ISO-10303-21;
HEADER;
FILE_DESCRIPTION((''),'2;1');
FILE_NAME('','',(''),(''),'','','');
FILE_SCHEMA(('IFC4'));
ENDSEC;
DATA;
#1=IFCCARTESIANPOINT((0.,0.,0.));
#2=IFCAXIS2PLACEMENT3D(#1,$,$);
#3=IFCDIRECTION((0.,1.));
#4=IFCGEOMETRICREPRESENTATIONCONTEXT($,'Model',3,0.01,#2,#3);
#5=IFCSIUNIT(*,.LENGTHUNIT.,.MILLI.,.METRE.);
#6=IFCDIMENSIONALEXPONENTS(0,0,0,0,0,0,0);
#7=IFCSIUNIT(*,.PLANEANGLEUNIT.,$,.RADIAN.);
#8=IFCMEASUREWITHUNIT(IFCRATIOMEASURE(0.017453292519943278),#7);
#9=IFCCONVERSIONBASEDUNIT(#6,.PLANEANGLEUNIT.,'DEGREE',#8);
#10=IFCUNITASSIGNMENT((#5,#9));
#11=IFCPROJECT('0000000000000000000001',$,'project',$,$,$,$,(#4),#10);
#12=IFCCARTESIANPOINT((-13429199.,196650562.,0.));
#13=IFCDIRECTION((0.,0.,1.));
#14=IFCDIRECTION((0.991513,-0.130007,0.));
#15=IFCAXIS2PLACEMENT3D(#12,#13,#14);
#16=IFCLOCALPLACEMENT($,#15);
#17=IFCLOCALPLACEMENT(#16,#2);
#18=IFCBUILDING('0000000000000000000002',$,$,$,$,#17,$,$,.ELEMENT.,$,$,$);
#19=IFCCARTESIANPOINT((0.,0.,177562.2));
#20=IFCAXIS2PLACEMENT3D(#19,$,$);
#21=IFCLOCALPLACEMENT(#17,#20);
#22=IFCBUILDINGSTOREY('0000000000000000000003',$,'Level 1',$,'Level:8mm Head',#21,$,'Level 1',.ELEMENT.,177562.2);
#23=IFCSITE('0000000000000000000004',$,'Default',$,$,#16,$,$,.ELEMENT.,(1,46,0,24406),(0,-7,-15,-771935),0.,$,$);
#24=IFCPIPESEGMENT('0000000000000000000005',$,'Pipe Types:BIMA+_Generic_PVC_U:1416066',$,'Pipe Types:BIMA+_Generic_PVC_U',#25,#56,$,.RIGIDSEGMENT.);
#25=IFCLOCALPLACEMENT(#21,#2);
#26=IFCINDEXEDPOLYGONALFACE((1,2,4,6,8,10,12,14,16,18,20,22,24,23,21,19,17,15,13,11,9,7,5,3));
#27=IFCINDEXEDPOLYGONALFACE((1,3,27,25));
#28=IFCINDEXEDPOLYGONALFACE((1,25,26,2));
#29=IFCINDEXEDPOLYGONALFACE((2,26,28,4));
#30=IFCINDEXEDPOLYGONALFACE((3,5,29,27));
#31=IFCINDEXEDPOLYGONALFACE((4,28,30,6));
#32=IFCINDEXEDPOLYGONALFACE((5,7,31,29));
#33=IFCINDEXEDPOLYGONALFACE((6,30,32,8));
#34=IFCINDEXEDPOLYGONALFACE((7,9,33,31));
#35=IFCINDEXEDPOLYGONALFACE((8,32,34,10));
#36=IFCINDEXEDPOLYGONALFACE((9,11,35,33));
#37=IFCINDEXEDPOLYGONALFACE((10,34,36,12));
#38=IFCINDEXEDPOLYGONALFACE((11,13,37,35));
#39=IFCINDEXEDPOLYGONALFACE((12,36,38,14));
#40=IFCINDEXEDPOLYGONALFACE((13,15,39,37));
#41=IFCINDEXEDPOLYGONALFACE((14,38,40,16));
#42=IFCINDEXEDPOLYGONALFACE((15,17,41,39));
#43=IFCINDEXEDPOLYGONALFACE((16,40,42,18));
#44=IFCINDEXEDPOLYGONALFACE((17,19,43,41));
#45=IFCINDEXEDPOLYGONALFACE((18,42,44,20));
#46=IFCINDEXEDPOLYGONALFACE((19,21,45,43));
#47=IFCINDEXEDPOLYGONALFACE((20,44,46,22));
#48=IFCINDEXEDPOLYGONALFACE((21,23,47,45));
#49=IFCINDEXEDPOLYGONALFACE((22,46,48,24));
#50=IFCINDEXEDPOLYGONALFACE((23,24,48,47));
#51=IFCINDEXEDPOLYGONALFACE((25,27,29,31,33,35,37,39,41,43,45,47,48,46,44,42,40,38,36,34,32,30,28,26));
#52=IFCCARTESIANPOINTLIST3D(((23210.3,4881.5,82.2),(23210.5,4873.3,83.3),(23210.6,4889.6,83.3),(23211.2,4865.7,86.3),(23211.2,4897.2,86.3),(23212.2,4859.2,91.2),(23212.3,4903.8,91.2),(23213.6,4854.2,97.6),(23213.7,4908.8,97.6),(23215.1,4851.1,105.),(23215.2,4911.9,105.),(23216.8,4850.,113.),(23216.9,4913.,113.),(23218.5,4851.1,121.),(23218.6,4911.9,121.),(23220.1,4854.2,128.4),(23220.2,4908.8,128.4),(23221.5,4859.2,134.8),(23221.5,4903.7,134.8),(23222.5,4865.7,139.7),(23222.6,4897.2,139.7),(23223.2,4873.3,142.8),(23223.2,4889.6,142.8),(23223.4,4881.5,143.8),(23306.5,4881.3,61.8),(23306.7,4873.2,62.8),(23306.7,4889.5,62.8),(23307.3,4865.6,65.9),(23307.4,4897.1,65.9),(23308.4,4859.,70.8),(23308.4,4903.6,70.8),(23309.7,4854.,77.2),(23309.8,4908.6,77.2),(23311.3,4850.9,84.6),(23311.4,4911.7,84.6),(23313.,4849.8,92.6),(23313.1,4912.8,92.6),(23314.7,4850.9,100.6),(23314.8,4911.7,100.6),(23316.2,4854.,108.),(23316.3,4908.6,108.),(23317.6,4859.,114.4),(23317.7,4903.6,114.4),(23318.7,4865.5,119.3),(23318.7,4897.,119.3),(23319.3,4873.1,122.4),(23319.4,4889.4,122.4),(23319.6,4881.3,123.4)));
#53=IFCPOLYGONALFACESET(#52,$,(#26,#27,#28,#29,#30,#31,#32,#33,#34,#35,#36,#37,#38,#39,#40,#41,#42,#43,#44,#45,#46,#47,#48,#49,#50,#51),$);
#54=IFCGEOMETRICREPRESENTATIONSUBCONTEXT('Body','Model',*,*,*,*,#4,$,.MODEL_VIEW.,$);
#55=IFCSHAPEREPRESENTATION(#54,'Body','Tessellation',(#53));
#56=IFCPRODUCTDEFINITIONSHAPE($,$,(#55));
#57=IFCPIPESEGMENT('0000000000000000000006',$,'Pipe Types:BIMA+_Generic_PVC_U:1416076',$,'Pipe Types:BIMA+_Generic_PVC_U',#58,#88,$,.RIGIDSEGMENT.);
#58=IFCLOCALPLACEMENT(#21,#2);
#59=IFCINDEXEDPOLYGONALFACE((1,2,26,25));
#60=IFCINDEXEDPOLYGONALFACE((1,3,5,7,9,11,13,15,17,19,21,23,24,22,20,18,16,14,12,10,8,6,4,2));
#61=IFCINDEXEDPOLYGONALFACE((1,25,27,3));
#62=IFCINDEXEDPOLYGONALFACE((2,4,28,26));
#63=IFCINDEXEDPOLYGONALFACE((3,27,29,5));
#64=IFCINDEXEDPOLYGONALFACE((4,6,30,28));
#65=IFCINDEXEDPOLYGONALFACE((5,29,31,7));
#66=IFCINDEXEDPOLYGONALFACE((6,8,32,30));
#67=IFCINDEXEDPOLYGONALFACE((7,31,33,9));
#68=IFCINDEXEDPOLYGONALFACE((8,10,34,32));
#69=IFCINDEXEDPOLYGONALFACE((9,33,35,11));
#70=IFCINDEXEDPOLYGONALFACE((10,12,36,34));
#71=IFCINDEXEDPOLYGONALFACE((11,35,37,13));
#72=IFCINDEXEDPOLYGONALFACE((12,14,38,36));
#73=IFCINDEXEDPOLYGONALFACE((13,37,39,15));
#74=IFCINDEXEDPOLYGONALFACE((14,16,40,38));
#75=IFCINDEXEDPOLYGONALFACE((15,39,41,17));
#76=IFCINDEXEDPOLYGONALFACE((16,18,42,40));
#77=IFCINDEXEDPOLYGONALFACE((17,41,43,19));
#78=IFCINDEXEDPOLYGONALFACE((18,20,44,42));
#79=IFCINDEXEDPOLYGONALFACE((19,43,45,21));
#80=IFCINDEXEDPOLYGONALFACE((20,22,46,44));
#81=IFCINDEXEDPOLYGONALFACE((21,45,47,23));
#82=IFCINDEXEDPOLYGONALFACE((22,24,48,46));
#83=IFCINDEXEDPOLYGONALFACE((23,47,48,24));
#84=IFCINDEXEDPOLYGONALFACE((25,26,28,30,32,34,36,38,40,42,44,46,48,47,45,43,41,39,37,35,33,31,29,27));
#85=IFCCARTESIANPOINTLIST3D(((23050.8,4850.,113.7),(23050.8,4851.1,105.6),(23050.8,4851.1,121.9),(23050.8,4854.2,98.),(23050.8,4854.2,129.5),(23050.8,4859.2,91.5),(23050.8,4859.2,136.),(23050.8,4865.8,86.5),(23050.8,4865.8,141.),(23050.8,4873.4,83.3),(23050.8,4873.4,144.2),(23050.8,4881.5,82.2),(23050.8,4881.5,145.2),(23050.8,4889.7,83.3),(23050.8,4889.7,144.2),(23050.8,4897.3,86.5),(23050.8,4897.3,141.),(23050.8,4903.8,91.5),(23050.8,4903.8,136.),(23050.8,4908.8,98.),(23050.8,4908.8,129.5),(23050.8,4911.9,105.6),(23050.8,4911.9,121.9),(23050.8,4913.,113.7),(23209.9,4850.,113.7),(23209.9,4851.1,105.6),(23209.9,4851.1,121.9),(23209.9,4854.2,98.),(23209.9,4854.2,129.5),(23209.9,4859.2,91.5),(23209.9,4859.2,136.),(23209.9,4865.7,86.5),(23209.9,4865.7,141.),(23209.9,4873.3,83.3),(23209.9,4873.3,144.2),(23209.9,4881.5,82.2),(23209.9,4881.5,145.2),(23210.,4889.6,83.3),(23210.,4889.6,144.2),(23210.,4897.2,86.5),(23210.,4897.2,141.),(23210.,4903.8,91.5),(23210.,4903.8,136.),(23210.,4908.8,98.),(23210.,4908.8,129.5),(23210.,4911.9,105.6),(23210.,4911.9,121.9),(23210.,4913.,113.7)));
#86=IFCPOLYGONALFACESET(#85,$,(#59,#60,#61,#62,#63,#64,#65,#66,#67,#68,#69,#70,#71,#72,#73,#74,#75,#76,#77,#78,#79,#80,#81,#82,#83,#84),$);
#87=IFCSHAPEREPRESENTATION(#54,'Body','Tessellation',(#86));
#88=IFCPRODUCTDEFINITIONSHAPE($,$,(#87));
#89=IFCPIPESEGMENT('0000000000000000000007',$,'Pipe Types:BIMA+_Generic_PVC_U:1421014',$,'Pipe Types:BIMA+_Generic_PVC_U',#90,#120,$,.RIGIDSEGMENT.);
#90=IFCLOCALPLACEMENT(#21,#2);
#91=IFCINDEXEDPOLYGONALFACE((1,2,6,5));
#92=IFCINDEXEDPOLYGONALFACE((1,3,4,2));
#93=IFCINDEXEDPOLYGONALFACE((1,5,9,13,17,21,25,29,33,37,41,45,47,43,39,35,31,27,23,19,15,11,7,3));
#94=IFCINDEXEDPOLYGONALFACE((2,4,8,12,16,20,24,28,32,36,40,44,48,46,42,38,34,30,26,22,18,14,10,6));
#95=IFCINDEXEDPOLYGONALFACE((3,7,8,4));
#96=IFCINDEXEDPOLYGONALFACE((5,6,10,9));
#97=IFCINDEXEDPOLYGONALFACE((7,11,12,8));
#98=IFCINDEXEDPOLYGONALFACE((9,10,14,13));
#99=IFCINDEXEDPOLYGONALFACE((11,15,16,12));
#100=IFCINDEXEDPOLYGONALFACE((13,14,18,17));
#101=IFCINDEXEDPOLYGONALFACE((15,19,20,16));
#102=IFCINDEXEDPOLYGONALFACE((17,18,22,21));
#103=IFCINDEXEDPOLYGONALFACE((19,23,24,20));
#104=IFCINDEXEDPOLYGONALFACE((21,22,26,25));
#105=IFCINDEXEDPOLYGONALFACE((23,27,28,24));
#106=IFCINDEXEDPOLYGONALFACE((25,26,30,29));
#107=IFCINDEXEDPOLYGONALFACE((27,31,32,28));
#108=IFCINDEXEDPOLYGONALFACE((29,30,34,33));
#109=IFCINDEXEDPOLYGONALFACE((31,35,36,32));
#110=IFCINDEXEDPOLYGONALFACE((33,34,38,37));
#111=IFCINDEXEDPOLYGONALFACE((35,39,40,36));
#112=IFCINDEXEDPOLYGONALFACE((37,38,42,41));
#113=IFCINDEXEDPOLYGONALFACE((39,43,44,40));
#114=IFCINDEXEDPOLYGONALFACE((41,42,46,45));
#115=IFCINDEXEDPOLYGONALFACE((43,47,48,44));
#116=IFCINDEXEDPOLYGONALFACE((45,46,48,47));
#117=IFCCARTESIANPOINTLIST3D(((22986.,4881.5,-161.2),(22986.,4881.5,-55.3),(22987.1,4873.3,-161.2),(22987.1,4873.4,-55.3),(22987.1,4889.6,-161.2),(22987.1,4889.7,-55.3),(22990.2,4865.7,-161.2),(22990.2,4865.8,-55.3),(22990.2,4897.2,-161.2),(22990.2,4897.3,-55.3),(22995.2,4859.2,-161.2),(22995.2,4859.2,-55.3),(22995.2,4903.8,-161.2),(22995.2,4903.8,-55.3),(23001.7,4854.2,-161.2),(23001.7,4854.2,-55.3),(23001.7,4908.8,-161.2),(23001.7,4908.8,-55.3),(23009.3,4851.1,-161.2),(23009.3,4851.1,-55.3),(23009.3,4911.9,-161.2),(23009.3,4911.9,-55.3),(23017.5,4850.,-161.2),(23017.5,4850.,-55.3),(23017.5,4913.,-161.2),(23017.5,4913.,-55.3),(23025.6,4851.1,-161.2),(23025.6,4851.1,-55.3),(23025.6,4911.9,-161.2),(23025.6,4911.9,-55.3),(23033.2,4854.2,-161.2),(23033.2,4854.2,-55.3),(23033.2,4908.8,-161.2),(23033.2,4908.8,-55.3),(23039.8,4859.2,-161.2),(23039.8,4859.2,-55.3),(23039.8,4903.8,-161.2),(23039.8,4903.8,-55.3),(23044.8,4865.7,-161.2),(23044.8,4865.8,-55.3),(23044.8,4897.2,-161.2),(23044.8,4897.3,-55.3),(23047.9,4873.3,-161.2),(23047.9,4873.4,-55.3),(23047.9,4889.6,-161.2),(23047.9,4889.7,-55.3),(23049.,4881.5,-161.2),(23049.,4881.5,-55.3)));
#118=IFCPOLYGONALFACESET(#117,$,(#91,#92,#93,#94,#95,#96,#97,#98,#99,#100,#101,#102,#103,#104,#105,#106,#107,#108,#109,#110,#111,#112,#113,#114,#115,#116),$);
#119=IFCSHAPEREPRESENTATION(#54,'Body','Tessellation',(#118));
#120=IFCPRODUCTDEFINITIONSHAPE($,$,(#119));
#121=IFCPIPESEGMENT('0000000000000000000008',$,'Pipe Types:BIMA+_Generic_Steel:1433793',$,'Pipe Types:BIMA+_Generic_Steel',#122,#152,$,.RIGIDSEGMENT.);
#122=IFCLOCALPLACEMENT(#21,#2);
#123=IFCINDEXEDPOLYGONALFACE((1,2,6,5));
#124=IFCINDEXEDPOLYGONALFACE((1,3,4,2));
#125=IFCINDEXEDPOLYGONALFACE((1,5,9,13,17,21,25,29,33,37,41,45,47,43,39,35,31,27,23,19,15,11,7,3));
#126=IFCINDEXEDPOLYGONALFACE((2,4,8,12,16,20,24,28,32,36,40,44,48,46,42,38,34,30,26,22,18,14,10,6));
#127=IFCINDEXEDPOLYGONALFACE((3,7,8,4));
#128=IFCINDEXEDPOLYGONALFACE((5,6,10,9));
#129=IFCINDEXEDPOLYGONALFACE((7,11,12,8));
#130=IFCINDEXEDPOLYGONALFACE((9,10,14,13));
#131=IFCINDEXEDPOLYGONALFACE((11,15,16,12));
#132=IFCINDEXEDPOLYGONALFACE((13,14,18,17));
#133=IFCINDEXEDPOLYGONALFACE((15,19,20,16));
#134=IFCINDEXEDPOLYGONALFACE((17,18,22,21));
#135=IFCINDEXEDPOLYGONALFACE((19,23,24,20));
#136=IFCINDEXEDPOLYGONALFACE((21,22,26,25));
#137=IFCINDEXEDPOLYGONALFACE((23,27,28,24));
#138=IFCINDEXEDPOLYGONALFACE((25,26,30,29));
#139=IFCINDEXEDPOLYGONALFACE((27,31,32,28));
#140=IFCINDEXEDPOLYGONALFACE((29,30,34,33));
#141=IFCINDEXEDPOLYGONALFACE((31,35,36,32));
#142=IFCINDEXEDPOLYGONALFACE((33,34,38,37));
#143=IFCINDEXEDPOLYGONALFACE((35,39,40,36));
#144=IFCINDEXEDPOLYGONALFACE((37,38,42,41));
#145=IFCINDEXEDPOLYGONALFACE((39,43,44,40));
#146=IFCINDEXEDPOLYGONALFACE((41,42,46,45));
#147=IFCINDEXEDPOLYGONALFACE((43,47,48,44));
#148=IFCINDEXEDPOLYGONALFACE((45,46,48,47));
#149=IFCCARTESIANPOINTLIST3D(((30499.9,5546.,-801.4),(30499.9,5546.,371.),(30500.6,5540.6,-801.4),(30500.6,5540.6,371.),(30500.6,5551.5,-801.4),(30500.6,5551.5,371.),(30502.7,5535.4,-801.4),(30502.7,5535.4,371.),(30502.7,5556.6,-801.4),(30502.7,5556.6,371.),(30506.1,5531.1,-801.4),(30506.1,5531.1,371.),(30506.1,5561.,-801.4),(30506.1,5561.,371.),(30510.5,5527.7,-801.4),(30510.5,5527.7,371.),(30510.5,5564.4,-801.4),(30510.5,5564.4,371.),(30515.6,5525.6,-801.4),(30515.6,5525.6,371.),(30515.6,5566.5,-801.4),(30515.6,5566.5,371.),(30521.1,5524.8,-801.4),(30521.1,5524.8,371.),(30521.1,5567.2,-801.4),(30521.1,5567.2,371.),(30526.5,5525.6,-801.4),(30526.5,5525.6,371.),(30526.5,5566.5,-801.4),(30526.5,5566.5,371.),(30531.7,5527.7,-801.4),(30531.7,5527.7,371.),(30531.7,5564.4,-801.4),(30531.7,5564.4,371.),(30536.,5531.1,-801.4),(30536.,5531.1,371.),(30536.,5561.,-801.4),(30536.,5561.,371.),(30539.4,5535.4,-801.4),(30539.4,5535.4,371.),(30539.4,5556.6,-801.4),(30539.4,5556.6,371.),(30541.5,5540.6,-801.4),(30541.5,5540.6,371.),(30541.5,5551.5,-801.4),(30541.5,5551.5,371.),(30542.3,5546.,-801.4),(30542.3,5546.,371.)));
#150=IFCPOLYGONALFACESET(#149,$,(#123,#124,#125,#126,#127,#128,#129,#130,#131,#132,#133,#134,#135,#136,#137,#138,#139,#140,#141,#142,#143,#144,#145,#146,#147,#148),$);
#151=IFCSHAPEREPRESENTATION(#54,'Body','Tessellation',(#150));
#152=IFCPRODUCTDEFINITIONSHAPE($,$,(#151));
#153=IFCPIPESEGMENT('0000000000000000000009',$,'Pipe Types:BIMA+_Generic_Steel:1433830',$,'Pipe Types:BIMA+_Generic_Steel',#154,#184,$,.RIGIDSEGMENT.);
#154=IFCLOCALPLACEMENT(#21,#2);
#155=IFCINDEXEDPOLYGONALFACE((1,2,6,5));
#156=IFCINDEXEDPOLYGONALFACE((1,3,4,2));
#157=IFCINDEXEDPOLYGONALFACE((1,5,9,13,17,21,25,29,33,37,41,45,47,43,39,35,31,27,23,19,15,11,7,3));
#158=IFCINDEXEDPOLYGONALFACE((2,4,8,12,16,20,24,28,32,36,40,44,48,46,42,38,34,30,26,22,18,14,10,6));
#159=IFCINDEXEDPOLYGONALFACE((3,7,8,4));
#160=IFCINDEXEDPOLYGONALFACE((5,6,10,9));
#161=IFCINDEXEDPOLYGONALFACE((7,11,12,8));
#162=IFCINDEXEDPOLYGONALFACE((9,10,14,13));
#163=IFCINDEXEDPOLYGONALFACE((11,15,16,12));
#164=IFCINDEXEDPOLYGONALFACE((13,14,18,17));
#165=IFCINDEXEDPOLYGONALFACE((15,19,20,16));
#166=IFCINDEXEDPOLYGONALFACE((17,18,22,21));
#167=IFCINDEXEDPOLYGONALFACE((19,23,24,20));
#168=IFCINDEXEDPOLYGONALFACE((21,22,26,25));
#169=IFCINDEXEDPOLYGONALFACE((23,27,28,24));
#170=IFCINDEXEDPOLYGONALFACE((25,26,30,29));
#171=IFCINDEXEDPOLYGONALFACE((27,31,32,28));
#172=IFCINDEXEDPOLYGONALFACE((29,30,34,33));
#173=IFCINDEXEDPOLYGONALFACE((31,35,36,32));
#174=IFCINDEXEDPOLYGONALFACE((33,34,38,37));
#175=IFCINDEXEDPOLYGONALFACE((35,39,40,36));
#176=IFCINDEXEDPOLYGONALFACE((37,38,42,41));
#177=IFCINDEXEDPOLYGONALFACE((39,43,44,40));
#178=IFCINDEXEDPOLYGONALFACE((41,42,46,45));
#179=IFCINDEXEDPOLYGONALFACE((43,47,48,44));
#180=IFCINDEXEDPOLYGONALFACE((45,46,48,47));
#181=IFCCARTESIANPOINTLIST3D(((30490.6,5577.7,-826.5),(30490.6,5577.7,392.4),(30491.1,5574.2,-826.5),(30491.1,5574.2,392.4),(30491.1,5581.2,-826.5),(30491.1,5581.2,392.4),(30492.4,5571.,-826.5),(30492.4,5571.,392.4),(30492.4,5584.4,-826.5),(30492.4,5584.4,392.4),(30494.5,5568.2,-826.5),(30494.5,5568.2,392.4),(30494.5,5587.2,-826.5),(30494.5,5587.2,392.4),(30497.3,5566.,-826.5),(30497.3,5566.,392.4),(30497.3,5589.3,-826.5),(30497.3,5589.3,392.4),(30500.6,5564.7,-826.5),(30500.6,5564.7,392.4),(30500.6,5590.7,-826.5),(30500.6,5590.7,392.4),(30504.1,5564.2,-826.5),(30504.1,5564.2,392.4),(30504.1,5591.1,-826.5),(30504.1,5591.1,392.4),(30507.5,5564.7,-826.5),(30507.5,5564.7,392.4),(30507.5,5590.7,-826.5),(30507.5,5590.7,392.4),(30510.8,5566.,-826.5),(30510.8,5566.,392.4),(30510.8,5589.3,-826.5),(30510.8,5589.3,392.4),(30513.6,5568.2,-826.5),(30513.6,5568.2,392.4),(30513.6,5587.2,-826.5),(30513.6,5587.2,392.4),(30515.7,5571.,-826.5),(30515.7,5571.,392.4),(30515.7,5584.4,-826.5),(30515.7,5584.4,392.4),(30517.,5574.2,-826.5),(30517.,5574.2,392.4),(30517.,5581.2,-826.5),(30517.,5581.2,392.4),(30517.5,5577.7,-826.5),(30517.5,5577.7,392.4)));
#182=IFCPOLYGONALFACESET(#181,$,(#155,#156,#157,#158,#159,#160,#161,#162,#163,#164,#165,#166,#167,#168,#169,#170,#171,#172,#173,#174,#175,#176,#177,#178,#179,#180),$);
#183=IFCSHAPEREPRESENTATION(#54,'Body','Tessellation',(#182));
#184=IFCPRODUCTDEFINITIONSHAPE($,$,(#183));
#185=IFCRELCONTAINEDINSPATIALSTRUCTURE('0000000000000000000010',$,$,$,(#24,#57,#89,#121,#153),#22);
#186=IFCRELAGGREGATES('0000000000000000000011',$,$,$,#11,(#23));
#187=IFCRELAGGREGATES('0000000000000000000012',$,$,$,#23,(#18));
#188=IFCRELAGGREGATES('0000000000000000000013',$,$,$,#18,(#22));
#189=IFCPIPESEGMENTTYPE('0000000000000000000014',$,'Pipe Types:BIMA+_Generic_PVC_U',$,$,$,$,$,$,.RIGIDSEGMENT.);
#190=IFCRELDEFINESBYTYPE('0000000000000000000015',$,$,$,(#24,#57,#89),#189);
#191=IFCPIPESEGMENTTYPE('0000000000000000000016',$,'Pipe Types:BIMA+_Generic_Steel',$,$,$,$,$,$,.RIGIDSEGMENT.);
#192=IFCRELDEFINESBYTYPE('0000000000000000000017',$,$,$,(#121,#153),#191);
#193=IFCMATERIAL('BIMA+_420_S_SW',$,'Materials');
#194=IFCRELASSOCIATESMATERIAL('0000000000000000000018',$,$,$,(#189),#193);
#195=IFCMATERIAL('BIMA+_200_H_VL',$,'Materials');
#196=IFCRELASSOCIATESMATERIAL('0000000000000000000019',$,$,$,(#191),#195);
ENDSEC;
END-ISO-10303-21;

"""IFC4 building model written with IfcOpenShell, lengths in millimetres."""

from ifc_helpers import new_model, entity, si_unit, converted_unit, direction, frame, origin, place, context, subcontext, project, spatial, arc, indexed_curve, outline, extrude, material, type_object, element, save


model = new_model("IFC4")

# Units and contexts
model_context = context("Model", 3, precision=0.01, world=origin(), true_north=direction((0.0, 1.0)))
body_context = subcontext(model_context, "Body", "Model", "MODEL_VIEW")
ifc_project = project(units=[si_unit("LENGTHUNIT", "METRE", prefix="MILLI"), converted_unit("PLANEANGLEUNIT", "DEGREE", entity("IfcRatioMeasure", 0.017453292519943278), si_unit("PLANEANGLEUNIT", "RADIAN"), dimensions=[0, 0, 0, 0, 0, 0, 0])], contexts=[model_context])

# Site, building, storey
site_placement = place(None, frame((-13429199.0, 196650562.0, 0.0), z_axis=(0.0, 0.0, 1.0), x_axis=(0.991513, -0.130007, 0.0)))
site = spatial("IfcSite", under=ifc_project, at=site_placement, Name="Default", CompositionType="ELEMENT", RefLatitude=(1, 46, 0, 24406), RefLongitude=(0, -7, -15, -771935), RefElevation=0.0)
building_placement = place(site_placement, origin())
building = spatial("IfcBuilding", under=site, at=building_placement, CompositionType="ELEMENT")
storey_placement = place(building_placement, frame((0.0, 0.0, 177562.2)))
storey = spatial("IfcBuildingStorey", under=building, at=storey_placement, Name="Level 1", ObjectType="Level:8mm Head", LongName="Level 1", CompositionType="ELEMENT", Elevation=177562.2)

# Pipe segments
ifc_material_1 = material(Name="BIMA+_420_S_SW", Category="Materials")
pipe_segment_type_1 = type_object("IfcPipeSegmentType", Name="Pipe Types:BIMA+_Generic_PVC_U", PredefinedType="RIGIDSEGMENT", material=ifc_material_1)
pipe_segment_1_placement = place(storey_placement, frame((23208.7, 4848.2, 145.4)))
element("IfcPipeSegment", 1, at=pipe_segment_1_placement, inside=storey, type_object=pipe_segment_type_1, Name="Pipe Types:BIMA+_Generic_PVC_U:1416066", ObjectType="Pipe Types:BIMA+_Generic_PVC_U", PredefinedType="RIGIDSEGMENT", context=body_context, shape_type="SweptSolid", body=[
    extrude(outline(indexed_curve([(31.5, 0.0), (22.3, 22.3), (0.0, 31.5), (-22.3, 22.3), (-31.5, 0.0), (-22.3, -22.3), (0.0, -31.5), (22.3, -22.3)], segments=[arc(1, 2, 3), arc(3, 4, 5), arc(5, 6, 7), arc(7, 8, 1)], self_intersect=False)), frame((104.3, 33.1, -52.8), z_axis=(-0.978183, 0.001783, 0.207737), x_axis=(0.001823, 0.999998, 0.0)), (0.0, 0.0, 1.0), 98.3),
])
pipe_segment_2_placement = place(storey_placement, frame((23050.8, 4848.4, 80.6)))
element("IfcPipeSegment", 2, at=pipe_segment_2_placement, inside=storey, type_object=pipe_segment_type_1, Name="Pipe Types:BIMA+_Generic_PVC_U:1416076", ObjectType="Pipe Types:BIMA+_Generic_PVC_U", PredefinedType="RIGIDSEGMENT", context=body_context, shape_type="SweptSolid", body=[
    extrude(outline(indexed_curve([(31.5, 0.0), (22.3, 22.3), (0.0, 31.5), (-22.3, 22.3), (-31.5, 0.0), (-22.3, -22.3), (0.0, -31.5), (22.3, -22.3)], segments=[arc(1, 2, 3), arc(3, 4, 5), arc(5, 6, 7), arc(7, 8, 1)], self_intersect=False)), frame((0.0, 33.1, 33.1), z_axis=(1.0, -0.000183, 0.0), x_axis=(-0.000183, -1.0, 0.0)), (0.0, 0.0, 1.0), 159.1),
])
pipe_segment_3_placement = place(storey_placement, frame((22984.4, 4848.4, -161.2)))
element("IfcPipeSegment", 3, at=pipe_segment_3_placement, inside=storey, type_object=pipe_segment_type_1, Name="Pipe Types:BIMA+_Generic_PVC_U:1421014", ObjectType="Pipe Types:BIMA+_Generic_PVC_U", PredefinedType="RIGIDSEGMENT", context=body_context, shape_type="SweptSolid", body=[
    extrude(outline(indexed_curve([(31.5, 0.0), (22.3, 22.3), (0.0, 31.5), (-22.3, 22.3), (-31.5, 0.0), (-22.3, -22.3), (0.0, -31.5), (22.3, -22.3)], segments=[arc(1, 2, 3), arc(3, 4, 5), arc(5, 6, 7), arc(7, 8, 1)], self_intersect=False)), frame((33.1, 33.1, 0.0), z_axis=(0.0, 0.000131, 1.0), x_axis=(1.0, 0.0, 0.0)), (0.0, 0.0, 1.0), 105.9),
])
ifc_material_2 = material(Name="BIMA+_200_H_VL", Category="Materials")
pipe_segment_type_2 = type_object("IfcPipeSegmentType", Name="Pipe Types:BIMA+_Generic_Steel", PredefinedType="RIGIDSEGMENT", material=ifc_material_2)
pipe_segment_4_placement = place(storey_placement, frame((30498.3, 5523.3, -801.4)))
element("IfcPipeSegment", 4, at=pipe_segment_4_placement, inside=storey, type_object=pipe_segment_type_2, Name="Pipe Types:BIMA+_Generic_Steel:1433793", ObjectType="Pipe Types:BIMA+_Generic_Steel", PredefinedType="RIGIDSEGMENT", context=body_context, shape_type="SweptSolid", body=[
    extrude(outline(indexed_curve([(21.2, 0.0), (15.0, 15.0), (0.0, 21.2), (-15.0, 15.0), (-21.2, 0.0), (-15.0, -15.0), (0.0, -21.2), (15.0, -15.0)], segments=[arc(1, 2, 3), arc(3, 4, 5), arc(5, 6, 7), arc(7, 8, 1)], self_intersect=False)), frame((22.8, 22.8, 0.0), z_axis=(0.0, 0.0, 1.0), x_axis=(-1.0, 0.0, 0.0)), (0.0, 0.0, 1.0), 1172.4),
])
pipe_segment_5_placement = place(storey_placement, frame((30489.0, 5562.7, -826.5)))
element("IfcPipeSegment", 5, at=pipe_segment_5_placement, inside=storey, type_object=pipe_segment_type_2, Name="Pipe Types:BIMA+_Generic_Steel:1433830", ObjectType="Pipe Types:BIMA+_Generic_Steel", PredefinedType="RIGIDSEGMENT", context=body_context, shape_type="SweptSolid", body=[
    extrude(outline(indexed_curve([(13.5, 0.0), (9.5, 9.5), (0.0, 13.5), (-9.5, 9.5), (-13.5, 0.0), (-9.5, -9.5), (0.0, -13.5), (9.5, -9.5)], segments=[arc(1, 2, 3), arc(3, 4, 5), arc(5, 6, 7), arc(7, 8, 1)], self_intersect=False)), frame((15.0, 15.0, 0.0), z_axis=(0.0, 0.0, 1.0), x_axis=(-1.0, 0.0, 0.0)), (0.0, 0.0, 1.0), 1218.9),
])

save(model, "model.ifc")
